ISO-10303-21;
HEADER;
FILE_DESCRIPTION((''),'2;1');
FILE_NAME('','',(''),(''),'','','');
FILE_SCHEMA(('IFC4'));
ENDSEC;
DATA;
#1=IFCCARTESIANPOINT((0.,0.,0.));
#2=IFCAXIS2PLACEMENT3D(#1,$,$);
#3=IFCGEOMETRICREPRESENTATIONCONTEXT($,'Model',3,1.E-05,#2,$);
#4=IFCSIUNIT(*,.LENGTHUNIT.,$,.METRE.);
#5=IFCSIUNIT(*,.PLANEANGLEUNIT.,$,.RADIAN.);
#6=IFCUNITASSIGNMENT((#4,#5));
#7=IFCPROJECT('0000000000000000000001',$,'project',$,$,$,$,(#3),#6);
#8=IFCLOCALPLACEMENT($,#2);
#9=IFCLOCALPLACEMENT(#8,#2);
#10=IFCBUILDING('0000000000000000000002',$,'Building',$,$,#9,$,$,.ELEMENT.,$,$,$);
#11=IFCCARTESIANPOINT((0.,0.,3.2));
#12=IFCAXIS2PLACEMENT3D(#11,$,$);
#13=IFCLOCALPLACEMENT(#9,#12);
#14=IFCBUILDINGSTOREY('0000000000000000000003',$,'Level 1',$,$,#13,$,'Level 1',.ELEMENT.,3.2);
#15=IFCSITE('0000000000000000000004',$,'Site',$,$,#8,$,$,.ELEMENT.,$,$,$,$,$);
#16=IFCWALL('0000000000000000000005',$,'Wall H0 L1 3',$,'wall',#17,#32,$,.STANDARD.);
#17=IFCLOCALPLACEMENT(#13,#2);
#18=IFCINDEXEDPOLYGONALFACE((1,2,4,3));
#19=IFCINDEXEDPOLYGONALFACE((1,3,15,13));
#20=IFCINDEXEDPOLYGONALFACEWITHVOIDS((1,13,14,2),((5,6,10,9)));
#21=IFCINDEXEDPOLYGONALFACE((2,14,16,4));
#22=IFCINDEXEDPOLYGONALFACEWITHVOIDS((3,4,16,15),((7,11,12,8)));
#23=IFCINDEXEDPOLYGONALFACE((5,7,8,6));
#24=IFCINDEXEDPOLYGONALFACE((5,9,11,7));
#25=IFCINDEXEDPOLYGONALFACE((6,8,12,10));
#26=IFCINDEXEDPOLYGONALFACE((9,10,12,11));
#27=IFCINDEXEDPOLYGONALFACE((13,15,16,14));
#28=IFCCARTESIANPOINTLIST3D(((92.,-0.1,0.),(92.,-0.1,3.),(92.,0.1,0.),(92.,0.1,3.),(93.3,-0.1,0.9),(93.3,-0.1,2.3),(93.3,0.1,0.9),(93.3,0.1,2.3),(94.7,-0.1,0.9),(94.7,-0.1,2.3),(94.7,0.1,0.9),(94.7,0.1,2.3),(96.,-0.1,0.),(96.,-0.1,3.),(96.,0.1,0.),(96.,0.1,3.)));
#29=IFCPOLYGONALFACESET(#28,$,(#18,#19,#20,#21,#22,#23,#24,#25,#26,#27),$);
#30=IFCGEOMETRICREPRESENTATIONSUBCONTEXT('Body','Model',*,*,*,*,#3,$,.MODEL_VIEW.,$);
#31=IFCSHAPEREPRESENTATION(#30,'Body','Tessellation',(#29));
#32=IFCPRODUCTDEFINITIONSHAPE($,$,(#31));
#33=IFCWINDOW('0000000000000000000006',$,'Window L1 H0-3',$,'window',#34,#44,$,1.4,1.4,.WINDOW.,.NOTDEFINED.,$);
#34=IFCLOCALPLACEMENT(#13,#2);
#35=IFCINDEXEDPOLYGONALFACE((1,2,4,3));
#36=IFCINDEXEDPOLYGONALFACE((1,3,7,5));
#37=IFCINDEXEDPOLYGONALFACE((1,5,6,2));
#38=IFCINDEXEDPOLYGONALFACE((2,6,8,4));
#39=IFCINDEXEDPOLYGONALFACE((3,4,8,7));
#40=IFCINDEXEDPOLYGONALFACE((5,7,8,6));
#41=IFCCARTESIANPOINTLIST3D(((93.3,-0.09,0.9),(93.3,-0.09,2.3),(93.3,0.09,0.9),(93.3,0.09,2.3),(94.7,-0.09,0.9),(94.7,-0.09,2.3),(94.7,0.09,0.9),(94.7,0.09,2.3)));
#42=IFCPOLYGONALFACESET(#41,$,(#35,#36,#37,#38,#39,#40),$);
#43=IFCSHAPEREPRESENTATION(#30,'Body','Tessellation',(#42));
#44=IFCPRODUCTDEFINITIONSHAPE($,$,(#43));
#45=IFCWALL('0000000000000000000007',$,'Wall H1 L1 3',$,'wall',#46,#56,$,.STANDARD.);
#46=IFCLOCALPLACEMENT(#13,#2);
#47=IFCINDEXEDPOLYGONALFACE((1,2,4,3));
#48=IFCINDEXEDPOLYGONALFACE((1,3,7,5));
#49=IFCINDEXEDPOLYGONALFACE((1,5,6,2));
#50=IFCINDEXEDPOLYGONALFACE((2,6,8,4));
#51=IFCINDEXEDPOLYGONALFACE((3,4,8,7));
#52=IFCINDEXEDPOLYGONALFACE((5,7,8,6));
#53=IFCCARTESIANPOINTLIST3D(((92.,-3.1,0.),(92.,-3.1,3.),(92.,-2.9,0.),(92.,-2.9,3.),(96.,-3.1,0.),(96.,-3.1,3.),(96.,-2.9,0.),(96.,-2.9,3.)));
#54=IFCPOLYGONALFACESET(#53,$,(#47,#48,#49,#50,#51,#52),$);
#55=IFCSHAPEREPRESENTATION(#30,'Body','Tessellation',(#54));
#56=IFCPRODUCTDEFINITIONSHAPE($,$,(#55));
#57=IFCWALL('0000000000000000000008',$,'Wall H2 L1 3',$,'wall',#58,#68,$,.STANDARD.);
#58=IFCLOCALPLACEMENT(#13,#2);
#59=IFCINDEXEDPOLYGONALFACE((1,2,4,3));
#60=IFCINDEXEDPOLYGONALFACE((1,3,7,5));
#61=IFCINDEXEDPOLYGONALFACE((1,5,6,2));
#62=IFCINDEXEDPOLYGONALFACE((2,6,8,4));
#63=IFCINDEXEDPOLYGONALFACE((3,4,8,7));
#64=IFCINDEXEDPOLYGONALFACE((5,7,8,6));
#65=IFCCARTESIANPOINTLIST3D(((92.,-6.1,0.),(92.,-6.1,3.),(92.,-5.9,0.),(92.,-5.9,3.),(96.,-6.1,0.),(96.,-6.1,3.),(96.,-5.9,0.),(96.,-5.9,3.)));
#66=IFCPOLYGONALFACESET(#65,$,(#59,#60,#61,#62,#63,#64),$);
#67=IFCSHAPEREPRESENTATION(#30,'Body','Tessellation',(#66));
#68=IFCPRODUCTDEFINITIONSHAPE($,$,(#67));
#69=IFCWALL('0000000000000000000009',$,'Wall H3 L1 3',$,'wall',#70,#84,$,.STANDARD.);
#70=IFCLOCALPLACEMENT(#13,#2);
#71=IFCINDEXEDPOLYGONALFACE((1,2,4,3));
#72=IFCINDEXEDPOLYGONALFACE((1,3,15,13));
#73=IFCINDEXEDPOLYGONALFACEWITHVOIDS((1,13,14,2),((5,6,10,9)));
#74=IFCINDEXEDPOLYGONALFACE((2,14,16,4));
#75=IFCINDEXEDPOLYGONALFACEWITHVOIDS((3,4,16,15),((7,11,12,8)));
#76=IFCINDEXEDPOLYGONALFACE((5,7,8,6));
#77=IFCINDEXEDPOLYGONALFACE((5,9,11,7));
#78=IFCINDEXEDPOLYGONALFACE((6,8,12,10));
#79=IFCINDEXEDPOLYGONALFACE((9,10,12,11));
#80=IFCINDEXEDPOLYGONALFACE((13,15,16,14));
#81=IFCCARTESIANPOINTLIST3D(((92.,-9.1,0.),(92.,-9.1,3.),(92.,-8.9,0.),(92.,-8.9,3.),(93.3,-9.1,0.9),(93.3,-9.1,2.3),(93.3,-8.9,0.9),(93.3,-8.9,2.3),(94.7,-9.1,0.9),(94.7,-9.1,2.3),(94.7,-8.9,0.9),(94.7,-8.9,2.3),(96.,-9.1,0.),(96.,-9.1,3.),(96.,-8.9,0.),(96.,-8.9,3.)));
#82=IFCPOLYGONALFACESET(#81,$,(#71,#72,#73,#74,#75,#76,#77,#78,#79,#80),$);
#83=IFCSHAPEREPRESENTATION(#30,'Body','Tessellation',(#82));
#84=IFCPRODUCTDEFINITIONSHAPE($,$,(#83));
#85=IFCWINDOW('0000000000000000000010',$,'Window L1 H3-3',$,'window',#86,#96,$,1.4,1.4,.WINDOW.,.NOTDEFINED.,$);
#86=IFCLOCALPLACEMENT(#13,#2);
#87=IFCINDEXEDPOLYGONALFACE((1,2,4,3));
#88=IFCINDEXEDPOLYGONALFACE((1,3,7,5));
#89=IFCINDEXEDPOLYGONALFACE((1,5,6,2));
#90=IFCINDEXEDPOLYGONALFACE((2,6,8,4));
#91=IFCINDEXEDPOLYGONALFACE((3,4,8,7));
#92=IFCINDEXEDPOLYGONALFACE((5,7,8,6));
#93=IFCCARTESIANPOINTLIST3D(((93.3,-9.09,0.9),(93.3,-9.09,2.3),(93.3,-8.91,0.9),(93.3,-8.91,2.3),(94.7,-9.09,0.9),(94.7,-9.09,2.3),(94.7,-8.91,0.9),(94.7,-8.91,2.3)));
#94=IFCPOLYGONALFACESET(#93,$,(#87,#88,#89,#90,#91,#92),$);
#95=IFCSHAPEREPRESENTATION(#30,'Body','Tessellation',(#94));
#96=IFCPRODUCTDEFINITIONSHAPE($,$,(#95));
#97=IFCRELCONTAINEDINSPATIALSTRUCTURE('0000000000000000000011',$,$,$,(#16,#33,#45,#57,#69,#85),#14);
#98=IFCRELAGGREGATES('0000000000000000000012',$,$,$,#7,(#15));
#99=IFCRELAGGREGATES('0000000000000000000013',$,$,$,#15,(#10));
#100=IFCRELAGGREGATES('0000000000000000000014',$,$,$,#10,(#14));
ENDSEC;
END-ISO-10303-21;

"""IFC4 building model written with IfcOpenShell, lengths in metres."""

from ifc_helpers import new_model, si_unit, frame, frame_2d, origin, origin_2d, place, context, subcontext, project, spatial, rectangle, extrude, element, fill, save


model = new_model("IFC4")

# Units and contexts
model_context = context("Model", 3, precision=1e-05, world=origin())
body_context = subcontext(model_context, "Body", "Model", "MODEL_VIEW")
ifc_project = project(units=[si_unit("LENGTHUNIT", "METRE"), si_unit("PLANEANGLEUNIT", "RADIAN")], contexts=[model_context])

# Site, building, storey
site_placement = place(None, origin())
site = spatial("IfcSite", under=ifc_project, at=site_placement, Name="Site", CompositionType="ELEMENT")
building_placement = place(site_placement, origin())
building = spatial("IfcBuilding", under=site, at=building_placement, Name="Building", CompositionType="ELEMENT")
storey_placement = place(building_placement, frame((0.0, 0.0, 3.2)))
storey = spatial("IfcBuildingStorey", under=building, at=storey_placement, Name="Level 1", LongName="Level 1", CompositionType="ELEMENT", Elevation=3.2)

# Wall, opening, window
wall_1_placement = place(storey_placement, frame((92.0, 0.0, 0.0), z_axis=(0.0, 0.0, 1.0), x_axis=(1.0, 0.0, 0.0)))
wall_1 = element("IfcWall", 1, at=wall_1_placement, inside=storey, Name="Wall H0 L1 3", ObjectType="wall", PredefinedType="STANDARD", context=body_context, shape_type="SweptSolid", body=[
    extrude(rectangle(XDim=4.0, YDim=0.2, at=frame_2d((2.0, 0.0))), origin(), (0.0, 0.0, 1.0), 3.0),
])
opening_1_placement = place(storey_placement, frame((94.0, 0.0, 0.9), z_axis=(0.0, 0.0, 1.0), x_axis=(1.0, 0.0, 0.0)))
opening_1 = element("IfcOpeningElement", 2, at=opening_1_placement, cuts=wall_1, ObjectType="Opening", PredefinedType="OPENING", context=body_context, shape_type="SweptSolid", body=[
    extrude(rectangle(XDim=1.4, YDim=0.22, at=origin_2d()), origin(), (0.0, 0.0, 1.0), 1.4),
])
window_1_placement = place(storey_placement, frame((94.0, 0.0, 0.9), z_axis=(0.0, 0.0, 1.0), x_axis=(1.0, 0.0, 0.0)))
window_1 = element("IfcWindow", 3, at=window_1_placement, inside=storey, Name="Window L1 H0-3", ObjectType="window", OverallHeight=1.4, OverallWidth=1.4, PartitioningType="NOTDEFINED", PredefinedType="WINDOW", context=body_context, shape_type="SweptSolid", body=[
    extrude(rectangle(XDim=1.4, YDim=0.18, at=origin_2d()), origin(), (0.0, 0.0, 1.0), 1.4),
])
fill(opening_1, window_1)

# Walls
for number, where, z_axis, x_axis, name in (
    (4, (92.0, -3.0, 0.0), (0.0, 0.0, 1.0), (1.0, 0.0, 0.0), "Wall H1 L1 3"),
    (5, (92.0, -6.0, 0.0), (0.0, 0.0, 1.0), (1.0, 0.0, 0.0), "Wall H2 L1 3"),
):
    element("IfcWall", number, at=place(storey_placement, frame(where, z_axis=z_axis, x_axis=x_axis)), inside=storey, Name=name, ObjectType="wall", PredefinedType="STANDARD", context=body_context, shape_type="SweptSolid", body=[
        extrude(rectangle(XDim=4.0, YDim=0.2, at=frame_2d((2.0, 0.0))), origin(), (0.0, 0.0, 1.0), 3.0),
    ])

# Wall, opening, window
wall_2_placement = place(storey_placement, frame((92.0, -9.0, 0.0), z_axis=(0.0, 0.0, 1.0), x_axis=(1.0, 0.0, 0.0)))
wall_2 = element("IfcWall", 6, at=wall_2_placement, inside=storey, Name="Wall H3 L1 3", ObjectType="wall", PredefinedType="STANDARD", context=body_context, shape_type="SweptSolid", body=[
    extrude(rectangle(XDim=4.0, YDim=0.2, at=frame_2d((2.0, 0.0))), origin(), (0.0, 0.0, 1.0), 3.0),
])
opening_2_placement = place(storey_placement, frame((94.0, -9.0, 0.9), z_axis=(0.0, 0.0, 1.0), x_axis=(1.0, 0.0, 0.0)))
opening_2 = element("IfcOpeningElement", 7, at=opening_2_placement, cuts=wall_2, ObjectType="Opening", PredefinedType="OPENING", context=body_context, shape_type="SweptSolid", body=[
    extrude(rectangle(XDim=1.4, YDim=0.22, at=origin_2d()), origin(), (0.0, 0.0, 1.0), 1.4),
])
window_2_placement = place(storey_placement, frame((94.0, -9.0, 0.9), z_axis=(0.0, 0.0, 1.0), x_axis=(1.0, 0.0, 0.0)))
window_2 = element("IfcWindow", 8, at=window_2_placement, inside=storey, Name="Window L1 H3-3", ObjectType="window", OverallHeight=1.4, OverallWidth=1.4, PartitioningType="NOTDEFINED", PredefinedType="WINDOW", context=body_context, shape_type="SweptSolid", body=[
    extrude(rectangle(XDim=1.4, YDim=0.18, at=origin_2d()), origin(), (0.0, 0.0, 1.0), 1.4),
])
fill(opening_2, window_2)

save(model, "model.ifc")
